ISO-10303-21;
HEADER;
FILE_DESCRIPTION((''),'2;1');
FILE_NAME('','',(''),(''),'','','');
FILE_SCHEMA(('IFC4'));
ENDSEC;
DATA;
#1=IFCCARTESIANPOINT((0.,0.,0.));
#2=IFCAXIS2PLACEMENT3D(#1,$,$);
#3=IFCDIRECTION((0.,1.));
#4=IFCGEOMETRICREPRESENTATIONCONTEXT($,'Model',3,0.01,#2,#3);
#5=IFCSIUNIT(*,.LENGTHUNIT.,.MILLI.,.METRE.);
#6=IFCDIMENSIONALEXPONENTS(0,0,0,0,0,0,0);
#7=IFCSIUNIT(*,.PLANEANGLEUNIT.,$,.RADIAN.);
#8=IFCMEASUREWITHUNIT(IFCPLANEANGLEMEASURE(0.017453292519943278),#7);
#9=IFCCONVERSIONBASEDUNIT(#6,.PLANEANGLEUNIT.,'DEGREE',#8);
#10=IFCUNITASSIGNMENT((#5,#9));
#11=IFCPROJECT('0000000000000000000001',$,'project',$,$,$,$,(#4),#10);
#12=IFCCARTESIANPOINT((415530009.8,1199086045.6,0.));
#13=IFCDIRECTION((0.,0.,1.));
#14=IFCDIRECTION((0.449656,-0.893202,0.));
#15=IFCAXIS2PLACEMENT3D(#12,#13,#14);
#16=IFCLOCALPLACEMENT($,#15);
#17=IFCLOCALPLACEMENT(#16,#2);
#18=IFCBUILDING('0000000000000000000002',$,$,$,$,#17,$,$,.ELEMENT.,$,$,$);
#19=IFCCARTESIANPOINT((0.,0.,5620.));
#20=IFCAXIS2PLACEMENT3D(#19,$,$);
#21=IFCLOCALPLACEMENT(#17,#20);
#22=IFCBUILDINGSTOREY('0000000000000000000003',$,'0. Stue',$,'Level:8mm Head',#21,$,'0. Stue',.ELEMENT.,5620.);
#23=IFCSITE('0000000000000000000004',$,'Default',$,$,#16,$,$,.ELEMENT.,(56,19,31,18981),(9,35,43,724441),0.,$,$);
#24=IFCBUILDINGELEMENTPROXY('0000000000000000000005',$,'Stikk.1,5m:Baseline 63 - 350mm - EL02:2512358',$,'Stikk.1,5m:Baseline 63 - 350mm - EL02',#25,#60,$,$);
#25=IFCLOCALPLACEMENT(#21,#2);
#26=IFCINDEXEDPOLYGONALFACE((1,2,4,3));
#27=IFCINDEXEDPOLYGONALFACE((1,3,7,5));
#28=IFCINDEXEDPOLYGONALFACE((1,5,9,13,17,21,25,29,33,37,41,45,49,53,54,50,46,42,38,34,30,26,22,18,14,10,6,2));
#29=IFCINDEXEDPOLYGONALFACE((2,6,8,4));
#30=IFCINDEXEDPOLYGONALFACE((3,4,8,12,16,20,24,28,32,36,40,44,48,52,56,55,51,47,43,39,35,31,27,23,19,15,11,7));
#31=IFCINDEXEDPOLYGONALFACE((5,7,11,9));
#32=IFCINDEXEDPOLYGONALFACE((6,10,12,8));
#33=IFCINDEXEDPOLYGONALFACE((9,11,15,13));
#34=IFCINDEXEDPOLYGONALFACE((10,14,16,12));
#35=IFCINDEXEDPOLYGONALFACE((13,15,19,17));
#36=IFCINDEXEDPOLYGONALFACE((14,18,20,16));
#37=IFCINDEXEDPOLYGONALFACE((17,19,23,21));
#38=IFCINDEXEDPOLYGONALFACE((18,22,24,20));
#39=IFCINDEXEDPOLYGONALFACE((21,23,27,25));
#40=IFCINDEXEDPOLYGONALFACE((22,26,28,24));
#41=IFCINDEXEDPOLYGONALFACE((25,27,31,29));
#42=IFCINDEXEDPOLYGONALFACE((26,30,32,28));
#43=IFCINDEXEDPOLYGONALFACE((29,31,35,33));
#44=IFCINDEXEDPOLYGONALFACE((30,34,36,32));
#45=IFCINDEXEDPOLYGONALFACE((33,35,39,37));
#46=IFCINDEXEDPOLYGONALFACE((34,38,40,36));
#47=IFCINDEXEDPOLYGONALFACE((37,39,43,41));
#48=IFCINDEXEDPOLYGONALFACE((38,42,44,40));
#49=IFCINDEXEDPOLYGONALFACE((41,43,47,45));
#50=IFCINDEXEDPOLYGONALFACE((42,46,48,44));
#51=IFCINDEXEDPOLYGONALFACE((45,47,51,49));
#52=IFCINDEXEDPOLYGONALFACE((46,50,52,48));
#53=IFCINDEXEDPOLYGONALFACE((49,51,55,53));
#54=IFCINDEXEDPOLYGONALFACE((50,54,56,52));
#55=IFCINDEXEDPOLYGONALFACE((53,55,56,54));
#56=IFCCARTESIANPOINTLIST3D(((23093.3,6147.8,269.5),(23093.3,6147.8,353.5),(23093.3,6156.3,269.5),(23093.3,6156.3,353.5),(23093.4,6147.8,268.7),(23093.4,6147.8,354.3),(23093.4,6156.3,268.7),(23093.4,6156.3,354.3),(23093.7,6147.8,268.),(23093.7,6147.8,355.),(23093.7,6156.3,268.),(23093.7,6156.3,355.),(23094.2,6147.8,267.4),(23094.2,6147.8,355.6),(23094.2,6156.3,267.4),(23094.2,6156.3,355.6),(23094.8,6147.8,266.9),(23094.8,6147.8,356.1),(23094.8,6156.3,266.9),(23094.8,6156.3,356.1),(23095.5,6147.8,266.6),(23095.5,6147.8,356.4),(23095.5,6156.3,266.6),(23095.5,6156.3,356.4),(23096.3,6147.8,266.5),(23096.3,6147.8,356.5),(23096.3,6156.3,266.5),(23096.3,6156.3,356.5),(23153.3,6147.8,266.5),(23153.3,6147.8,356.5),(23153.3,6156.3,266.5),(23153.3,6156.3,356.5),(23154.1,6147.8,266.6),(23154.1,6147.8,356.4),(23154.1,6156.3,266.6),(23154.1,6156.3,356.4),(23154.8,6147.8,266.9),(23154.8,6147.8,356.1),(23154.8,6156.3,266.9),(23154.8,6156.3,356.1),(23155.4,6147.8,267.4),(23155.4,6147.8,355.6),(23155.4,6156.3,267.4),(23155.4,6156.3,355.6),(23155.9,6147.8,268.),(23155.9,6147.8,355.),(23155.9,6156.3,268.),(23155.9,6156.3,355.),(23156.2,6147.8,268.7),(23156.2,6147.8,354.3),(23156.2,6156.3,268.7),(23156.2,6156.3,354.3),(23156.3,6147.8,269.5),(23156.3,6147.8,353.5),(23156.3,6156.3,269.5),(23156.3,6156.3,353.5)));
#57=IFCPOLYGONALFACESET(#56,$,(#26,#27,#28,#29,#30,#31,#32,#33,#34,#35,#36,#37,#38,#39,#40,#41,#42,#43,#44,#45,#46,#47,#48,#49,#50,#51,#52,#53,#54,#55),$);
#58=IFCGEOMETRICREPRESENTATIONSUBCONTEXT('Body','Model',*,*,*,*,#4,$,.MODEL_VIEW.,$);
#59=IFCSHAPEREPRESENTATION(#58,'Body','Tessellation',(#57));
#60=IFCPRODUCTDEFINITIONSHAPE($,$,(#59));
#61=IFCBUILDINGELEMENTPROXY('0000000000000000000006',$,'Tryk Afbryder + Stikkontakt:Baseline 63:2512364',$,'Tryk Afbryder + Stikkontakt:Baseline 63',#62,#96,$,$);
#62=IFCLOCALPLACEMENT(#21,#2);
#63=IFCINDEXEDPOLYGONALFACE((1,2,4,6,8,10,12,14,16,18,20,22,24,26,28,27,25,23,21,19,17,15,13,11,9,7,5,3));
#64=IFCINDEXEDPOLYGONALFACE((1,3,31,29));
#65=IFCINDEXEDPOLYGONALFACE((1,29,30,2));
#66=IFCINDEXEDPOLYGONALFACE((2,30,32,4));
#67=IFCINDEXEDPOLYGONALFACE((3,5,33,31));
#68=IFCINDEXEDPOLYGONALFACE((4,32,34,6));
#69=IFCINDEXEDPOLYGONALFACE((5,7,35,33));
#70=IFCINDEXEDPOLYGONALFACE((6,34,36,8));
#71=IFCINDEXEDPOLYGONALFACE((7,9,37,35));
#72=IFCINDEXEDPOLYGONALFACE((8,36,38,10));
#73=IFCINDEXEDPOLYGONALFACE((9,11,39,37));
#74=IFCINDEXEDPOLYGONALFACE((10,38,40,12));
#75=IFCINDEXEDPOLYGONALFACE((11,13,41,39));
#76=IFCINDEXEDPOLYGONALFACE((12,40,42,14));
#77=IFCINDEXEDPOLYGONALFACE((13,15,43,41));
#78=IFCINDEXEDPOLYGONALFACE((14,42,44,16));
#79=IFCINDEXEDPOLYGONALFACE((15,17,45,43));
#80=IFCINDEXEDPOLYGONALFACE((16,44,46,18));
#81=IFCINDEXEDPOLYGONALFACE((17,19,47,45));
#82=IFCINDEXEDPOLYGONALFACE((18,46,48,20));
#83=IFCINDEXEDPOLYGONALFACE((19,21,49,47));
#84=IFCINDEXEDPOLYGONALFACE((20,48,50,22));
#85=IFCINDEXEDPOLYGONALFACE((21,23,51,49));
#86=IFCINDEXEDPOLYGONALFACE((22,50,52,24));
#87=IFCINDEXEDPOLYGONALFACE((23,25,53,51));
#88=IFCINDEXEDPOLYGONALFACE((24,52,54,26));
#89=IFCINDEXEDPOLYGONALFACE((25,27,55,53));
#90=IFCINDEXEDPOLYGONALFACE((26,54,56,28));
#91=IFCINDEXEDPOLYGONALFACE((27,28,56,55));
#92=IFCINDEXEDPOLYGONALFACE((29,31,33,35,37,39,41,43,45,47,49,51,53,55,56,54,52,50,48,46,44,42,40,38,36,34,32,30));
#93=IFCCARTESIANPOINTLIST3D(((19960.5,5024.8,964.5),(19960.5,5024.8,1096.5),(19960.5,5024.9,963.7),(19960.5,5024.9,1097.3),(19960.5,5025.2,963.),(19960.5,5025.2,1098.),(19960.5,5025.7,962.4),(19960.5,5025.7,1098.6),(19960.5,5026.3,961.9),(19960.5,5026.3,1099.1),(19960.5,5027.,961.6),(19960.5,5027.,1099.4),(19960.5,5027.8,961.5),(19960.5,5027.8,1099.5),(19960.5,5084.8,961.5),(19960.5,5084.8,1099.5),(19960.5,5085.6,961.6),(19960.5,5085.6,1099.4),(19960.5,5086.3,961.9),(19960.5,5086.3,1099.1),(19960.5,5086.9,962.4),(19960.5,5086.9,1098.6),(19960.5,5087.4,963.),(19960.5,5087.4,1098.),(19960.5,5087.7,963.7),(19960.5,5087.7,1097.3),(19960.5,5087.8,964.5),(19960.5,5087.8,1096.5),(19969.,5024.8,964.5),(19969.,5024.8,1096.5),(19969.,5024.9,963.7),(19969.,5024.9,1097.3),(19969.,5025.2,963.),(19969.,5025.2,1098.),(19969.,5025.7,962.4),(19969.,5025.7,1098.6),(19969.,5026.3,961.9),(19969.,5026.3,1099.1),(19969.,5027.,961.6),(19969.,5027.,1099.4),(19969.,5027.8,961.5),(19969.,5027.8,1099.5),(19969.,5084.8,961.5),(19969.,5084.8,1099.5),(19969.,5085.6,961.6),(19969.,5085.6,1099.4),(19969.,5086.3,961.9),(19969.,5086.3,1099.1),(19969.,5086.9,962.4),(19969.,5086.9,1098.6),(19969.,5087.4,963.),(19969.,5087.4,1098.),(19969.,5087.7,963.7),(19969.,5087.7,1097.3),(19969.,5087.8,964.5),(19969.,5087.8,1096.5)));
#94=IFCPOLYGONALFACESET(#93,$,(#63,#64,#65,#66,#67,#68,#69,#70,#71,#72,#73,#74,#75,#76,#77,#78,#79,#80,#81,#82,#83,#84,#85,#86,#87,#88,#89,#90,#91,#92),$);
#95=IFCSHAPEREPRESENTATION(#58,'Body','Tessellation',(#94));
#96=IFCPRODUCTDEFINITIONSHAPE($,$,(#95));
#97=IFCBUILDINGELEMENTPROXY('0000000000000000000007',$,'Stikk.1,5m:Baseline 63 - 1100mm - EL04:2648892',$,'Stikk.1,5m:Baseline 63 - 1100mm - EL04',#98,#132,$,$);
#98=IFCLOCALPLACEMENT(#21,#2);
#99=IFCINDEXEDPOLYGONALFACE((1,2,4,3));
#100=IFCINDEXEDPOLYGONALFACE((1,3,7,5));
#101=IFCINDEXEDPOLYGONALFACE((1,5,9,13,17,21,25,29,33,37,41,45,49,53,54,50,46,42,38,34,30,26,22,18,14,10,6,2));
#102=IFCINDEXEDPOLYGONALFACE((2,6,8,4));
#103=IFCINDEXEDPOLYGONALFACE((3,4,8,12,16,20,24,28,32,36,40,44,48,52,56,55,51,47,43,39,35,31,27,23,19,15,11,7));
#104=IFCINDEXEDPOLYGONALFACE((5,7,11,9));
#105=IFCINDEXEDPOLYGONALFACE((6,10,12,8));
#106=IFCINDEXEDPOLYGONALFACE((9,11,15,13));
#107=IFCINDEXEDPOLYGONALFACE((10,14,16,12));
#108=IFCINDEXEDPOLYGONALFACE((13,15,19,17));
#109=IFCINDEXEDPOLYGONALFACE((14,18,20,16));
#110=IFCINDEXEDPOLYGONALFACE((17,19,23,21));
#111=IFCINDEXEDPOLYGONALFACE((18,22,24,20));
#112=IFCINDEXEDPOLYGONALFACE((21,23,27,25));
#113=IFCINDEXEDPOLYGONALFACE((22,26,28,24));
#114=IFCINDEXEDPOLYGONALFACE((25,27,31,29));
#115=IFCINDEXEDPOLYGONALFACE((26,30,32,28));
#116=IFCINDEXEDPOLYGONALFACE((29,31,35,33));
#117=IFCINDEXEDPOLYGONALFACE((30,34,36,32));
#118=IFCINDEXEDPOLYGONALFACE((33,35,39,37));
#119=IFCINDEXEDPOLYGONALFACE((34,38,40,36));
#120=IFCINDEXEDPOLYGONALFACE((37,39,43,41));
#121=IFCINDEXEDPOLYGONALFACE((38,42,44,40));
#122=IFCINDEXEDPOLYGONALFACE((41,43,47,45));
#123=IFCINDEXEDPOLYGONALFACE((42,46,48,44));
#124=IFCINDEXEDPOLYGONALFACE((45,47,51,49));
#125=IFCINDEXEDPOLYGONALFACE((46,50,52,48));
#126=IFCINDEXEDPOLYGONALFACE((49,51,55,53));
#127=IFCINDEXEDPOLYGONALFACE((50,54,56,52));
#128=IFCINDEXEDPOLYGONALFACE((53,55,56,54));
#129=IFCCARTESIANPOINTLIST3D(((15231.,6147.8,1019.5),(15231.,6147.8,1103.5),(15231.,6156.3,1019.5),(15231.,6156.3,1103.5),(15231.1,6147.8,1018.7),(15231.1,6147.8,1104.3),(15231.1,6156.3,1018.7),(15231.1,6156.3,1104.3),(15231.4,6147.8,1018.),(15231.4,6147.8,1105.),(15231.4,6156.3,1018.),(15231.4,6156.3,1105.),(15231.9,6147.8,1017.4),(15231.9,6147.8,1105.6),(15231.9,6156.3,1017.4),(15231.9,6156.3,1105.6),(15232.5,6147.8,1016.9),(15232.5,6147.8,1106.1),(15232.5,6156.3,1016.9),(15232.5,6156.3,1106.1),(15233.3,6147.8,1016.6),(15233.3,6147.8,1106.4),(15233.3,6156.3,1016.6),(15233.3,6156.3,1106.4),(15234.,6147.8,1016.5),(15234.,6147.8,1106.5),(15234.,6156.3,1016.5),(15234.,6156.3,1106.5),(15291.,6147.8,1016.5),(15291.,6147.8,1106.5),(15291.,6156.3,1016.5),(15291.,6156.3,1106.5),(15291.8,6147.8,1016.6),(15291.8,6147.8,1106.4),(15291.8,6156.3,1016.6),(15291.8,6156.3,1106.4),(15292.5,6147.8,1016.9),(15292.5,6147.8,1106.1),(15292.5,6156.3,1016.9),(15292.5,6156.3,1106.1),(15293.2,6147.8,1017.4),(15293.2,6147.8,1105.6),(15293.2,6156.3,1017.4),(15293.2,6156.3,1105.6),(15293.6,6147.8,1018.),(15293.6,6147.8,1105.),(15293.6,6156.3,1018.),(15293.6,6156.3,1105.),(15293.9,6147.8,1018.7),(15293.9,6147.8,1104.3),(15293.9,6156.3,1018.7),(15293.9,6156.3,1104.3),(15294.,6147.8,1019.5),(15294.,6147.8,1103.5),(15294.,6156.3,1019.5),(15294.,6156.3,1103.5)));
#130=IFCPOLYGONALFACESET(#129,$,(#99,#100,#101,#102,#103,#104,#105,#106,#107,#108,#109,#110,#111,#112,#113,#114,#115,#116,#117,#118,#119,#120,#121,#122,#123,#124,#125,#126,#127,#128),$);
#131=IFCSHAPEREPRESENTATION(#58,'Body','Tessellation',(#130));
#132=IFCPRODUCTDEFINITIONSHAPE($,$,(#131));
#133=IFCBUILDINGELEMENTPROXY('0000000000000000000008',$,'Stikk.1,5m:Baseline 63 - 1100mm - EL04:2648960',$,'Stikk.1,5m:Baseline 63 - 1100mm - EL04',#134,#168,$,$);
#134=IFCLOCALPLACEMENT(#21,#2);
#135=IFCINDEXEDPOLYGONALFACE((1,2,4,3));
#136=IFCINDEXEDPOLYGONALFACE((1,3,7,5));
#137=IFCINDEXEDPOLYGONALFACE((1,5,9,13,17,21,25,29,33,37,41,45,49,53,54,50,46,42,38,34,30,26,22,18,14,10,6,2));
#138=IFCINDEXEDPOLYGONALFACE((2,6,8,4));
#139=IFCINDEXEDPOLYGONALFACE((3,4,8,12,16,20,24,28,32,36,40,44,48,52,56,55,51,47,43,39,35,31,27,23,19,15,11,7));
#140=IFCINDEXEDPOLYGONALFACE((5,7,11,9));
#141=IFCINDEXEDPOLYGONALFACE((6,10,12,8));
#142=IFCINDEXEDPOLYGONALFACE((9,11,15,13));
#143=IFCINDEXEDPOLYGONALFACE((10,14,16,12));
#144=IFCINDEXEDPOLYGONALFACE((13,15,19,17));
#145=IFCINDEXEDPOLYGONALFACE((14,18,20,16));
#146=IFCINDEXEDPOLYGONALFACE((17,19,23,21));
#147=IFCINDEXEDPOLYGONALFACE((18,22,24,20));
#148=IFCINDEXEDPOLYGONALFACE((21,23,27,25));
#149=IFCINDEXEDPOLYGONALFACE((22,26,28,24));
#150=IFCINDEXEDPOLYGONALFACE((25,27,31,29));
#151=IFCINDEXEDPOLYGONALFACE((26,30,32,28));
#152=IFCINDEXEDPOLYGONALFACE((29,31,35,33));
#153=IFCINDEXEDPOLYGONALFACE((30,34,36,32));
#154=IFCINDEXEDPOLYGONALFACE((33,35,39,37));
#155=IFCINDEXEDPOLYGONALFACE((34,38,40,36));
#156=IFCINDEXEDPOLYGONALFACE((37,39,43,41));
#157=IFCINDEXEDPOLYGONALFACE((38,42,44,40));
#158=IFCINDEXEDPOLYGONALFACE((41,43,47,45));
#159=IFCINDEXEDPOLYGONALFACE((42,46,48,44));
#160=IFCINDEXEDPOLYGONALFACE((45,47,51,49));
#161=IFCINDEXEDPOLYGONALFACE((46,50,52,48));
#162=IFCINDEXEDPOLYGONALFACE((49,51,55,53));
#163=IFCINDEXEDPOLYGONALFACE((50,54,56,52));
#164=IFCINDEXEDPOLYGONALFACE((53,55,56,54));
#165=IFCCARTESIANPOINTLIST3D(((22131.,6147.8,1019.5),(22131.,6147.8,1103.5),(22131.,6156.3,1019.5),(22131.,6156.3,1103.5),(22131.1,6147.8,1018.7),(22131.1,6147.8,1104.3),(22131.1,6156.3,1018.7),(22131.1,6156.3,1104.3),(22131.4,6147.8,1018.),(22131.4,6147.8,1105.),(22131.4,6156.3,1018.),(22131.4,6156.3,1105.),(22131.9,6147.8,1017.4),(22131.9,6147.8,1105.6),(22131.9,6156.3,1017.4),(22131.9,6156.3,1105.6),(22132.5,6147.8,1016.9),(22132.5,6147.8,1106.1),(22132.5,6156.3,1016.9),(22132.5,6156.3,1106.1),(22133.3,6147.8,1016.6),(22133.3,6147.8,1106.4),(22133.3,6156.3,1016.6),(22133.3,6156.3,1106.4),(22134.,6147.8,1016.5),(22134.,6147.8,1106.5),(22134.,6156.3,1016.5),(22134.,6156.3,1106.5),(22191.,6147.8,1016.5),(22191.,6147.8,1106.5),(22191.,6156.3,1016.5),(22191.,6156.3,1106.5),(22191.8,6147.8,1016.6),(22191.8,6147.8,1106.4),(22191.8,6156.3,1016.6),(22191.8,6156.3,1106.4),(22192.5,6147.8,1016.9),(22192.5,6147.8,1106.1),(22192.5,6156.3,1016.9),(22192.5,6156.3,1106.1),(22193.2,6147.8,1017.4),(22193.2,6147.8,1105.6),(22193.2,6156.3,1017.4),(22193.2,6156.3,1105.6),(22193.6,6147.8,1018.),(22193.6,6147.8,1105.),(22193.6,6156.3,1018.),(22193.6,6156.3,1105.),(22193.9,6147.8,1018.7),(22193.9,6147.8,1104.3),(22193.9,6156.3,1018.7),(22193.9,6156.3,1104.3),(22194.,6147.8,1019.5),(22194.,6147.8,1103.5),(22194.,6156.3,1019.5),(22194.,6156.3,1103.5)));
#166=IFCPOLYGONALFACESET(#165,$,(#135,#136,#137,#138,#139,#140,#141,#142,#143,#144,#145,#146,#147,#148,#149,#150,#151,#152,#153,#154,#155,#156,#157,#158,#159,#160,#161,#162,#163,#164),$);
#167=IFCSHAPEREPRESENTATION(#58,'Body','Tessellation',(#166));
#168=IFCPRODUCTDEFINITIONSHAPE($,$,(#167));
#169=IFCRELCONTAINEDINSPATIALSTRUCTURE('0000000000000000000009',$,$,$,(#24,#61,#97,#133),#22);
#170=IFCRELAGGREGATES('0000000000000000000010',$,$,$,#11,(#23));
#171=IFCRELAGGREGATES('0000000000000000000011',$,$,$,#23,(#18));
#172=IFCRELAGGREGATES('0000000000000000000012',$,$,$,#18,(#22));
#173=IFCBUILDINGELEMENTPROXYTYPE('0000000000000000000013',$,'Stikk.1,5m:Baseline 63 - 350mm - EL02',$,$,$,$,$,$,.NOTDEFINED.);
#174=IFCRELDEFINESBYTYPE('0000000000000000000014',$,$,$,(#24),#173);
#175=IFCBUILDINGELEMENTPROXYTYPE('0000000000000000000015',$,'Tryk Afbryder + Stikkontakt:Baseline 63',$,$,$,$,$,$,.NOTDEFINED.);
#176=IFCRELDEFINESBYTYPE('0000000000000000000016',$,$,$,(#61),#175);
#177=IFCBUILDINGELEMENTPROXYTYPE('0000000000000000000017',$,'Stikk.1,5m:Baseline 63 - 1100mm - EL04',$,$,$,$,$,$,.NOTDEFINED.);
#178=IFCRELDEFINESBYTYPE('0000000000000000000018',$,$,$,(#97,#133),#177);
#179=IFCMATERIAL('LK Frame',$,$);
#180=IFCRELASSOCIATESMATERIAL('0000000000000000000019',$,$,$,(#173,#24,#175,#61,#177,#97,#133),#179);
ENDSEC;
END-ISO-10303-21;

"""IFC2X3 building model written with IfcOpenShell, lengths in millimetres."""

from ifc_helpers import new_model, entity, si_unit, converted_unit, direction, frame, frame_2d, origin, place, context, subcontext, project, spatial, polyline, circle_curve, parameter, trimmed, segment, composite_curve, outline, extrude, source, transform, mapped, material, type_object, type_shapes, element, save


model = new_model("IFC2X3")

# Units and contexts
model_context = context("Model", 3, precision=0.01, world=origin(), true_north=direction((0.0, 1.0)))
body_context = subcontext(model_context, "Body", "Model", "MODEL_VIEW")
ifc_project = project(units=[si_unit("LENGTHUNIT", "METRE", prefix="MILLI"), converted_unit("PLANEANGLEUNIT", "DEGREE", entity("IfcPlaneAngleMeasure", 0.017453292519943278), si_unit("PLANEANGLEUNIT", "RADIAN"), dimensions=[0, 0, 0, 0, 0, 0, 0])], contexts=[model_context])

# Site, building, storey
site_placement = place(None, frame((415530009.8, 1199086045.6, 0.0), z_axis=(0.0, 0.0, 1.0), x_axis=(0.449656, -0.893202, 0.0)))
site = spatial("IfcSite", under=ifc_project, at=site_placement, Name="Default", CompositionType="ELEMENT", RefLatitude=(56, 19, 31, 18981), RefLongitude=(9, 35, 43, 724441), RefElevation=0.0)
building_placement = place(site_placement, origin())
building = spatial("IfcBuilding", under=site, at=building_placement, CompositionType="ELEMENT")
storey_placement = place(building_placement, frame((0.0, 0.0, 5620.0)))
storey = spatial("IfcBuildingStorey", under=building, at=storey_placement, Name="0. Stue", ObjectType="Level:8mm Head", LongName="0. Stue", CompositionType="ELEMENT", Elevation=5620.0)

# Building element proxies
ifc_material_1 = material(Name="LK Frame")
building_element_proxy_type_1 = type_object("IfcBuildingElementProxyType", Name="Stikk.1,5m:Baseline 63 - 350mm - EL02", PredefinedType="NOTDEFINED", material=ifc_material_1)
shared_shape_1 = source(origin(), body_context, "Body", "SweptSolid", [
    extrude(outline(composite_curve([segment(polyline([(-42.0, -31.5), (42.0, -31.5)]), True, "CONTINUOUS"), segment(trimmed(circle_curve(frame_2d((42.0, -28.5), x_axis=(-1.0, 0.0)), 3.0), [parameter(90.0)], [parameter(180.0)], True, "PARAMETER"), True, "CONTINUOUS"), segment(polyline([(45.0, -28.5), (45.0, 28.5)]), True, "CONTINUOUS"), segment(trimmed(circle_curve(frame_2d((42.0, 28.5), x_axis=(-1.0, 0.0)), 3.0), [parameter(180.0)], [parameter(270.0)], True, "PARAMETER"), True, "CONTINUOUS"), segment(polyline([(42.0, 31.5), (-42.0, 31.5)]), True, "CONTINUOUS"), segment(trimmed(circle_curve(frame_2d((-42.0, 28.5), x_axis=(1.0, 0.0)), 3.0), [parameter(90.0)], [parameter(180.0)], True, "PARAMETER"), True, "CONTINUOUS"), segment(polyline([(-45.0, 28.5), (-45.0, -28.5)]), True, "CONTINUOUS"), segment(trimmed(circle_curve(frame_2d((-42.0, -28.5), x_axis=(1.0, 0.0)), 3.0), [parameter(180.0)], [parameter(270.0)], True, "PARAMETER"), True, "CONTINUOUS")], self_intersect=False)), frame((0.0, -38.5, 0.0), z_axis=(0.0, 0.0, 1.0), x_axis=(0.0, 1.0, 0.0)), (0.0, 0.0, 1.0), 8.5),
])
type_shapes(building_element_proxy_type_1, [shared_shape_1])
for number, where, z_axis, x_axis, name in (
    (1, (23124.8, 6156.3, 350.0), (0.0, -1.0, 0.0), (1.0, 0.0, 0.0), "Stikk.1,5m:Baseline 63 - 350mm - EL02:2512358"),
):
    element("IfcBuildingElementProxy", number, at=place(storey_placement, frame(where, z_axis=z_axis, x_axis=x_axis)), inside=storey, type_object=building_element_proxy_type_1, material=ifc_material_1, Name=name, ObjectType="Stikk.1,5m:Baseline 63 - 350mm - EL02", context=body_context, shape_type="MappedRepresentation", body=[
        mapped(shared_shape_1, transform((0.0, 0.0, 0.0), scale=1.0)),
    ])
building_element_proxy_type_2 = type_object("IfcBuildingElementProxyType", Name="Tryk Afbryder + Stikkontakt:Baseline 63", PredefinedType="NOTDEFINED", material=ifc_material_1)
shared_shape_2 = source(origin(), body_context, "Body", "SweptSolid", [
    extrude(outline(composite_curve([segment(polyline([(-66.0, -31.5), (66.0, -31.5)]), True, "CONTINUOUS"), segment(trimmed(circle_curve(frame_2d((66.0, -28.5), x_axis=(-1.0, 0.0)), 3.0), [parameter(90.0)], [parameter(180.0)], True, "PARAMETER"), True, "CONTINUOUS"), segment(polyline([(69.0, -28.5), (69.0, 28.5)]), True, "CONTINUOUS"), segment(trimmed(circle_curve(frame_2d((66.0, 28.5), x_axis=(-1.0, 0.0)), 3.0), [parameter(180.0)], [parameter(270.0)], True, "PARAMETER"), True, "CONTINUOUS"), segment(polyline([(66.0, 31.5), (-66.0, 31.5)]), True, "CONTINUOUS"), segment(trimmed(circle_curve(frame_2d((-66.0, 28.5), x_axis=(1.0, 0.0)), 3.0), [parameter(90.0)], [parameter(180.0)], True, "PARAMETER"), True, "CONTINUOUS"), segment(polyline([(-69.0, 28.5), (-69.0, -28.5)]), True, "CONTINUOUS"), segment(trimmed(circle_curve(frame_2d((-66.0, -28.5), x_axis=(1.0, 0.0)), 3.0), [parameter(180.0)], [parameter(270.0)], True, "PARAMETER"), True, "CONTINUOUS")], self_intersect=False)), frame((0.0, -69.5, 0.0), z_axis=(0.0, 0.0, 1.0), x_axis=(0.0, 1.0, 0.0)), (0.0, 0.0, 1.0), 8.5),
])
type_shapes(building_element_proxy_type_2, [shared_shape_2])
proxy_1_placement = place(storey_placement, frame((19960.5, 5056.3, 1100.0), z_axis=(1.0, 0.0, 0.0), x_axis=(0.0, 1.0, 0.0)))
element("IfcBuildingElementProxy", 2, at=proxy_1_placement, inside=storey, type_object=building_element_proxy_type_2, material=ifc_material_1, Name="Tryk Afbryder + Stikkontakt:Baseline 63:2512364", ObjectType="Tryk Afbryder + Stikkontakt:Baseline 63", context=body_context, shape_type="MappedRepresentation", body=[
    mapped(shared_shape_2, transform((0.0, 0.0, 0.0), scale=1.0)),
])
building_element_proxy_type_3 = type_object("IfcBuildingElementProxyType", Name="Stikk.1,5m:Baseline 63 - 1100mm - EL04", PredefinedType="NOTDEFINED", material=ifc_material_1)
shared_shape_3 = source(origin(), body_context, "Body", "SweptSolid", [
    extrude(outline(composite_curve([segment(trimmed(circle_curve(frame_2d((-42.0, 28.5), x_axis=(1.0, 0.0)), 3.0), [parameter(90.0)], [parameter(180.0)], True, "PARAMETER"), True, "CONTINUOUS"), segment(polyline([(-45.0, 28.5), (-45.0, -28.5)]), True, "CONTINUOUS"), segment(trimmed(circle_curve(frame_2d((-42.0, -28.5), x_axis=(1.0, 0.0)), 3.0), [parameter(180.0)], [parameter(270.0)], True, "PARAMETER"), True, "CONTINUOUS"), segment(polyline([(-42.0, -31.5), (42.0, -31.5)]), True, "CONTINUOUS"), segment(trimmed(circle_curve(frame_2d((42.0, -28.5), x_axis=(-1.0, 0.0)), 3.0), [parameter(90.0)], [parameter(180.0)], True, "PARAMETER"), True, "CONTINUOUS"), segment(polyline([(45.0, -28.5), (45.0, 28.5)]), True, "CONTINUOUS"), segment(trimmed(circle_curve(frame_2d((42.0, 28.5), x_axis=(-1.0, 0.0)), 3.0), [parameter(180.0)], [parameter(270.0)], True, "PARAMETER"), True, "CONTINUOUS"), segment(polyline([(42.0, 31.5), (-42.0, 31.5)]), True, "CONTINUOUS")], self_intersect=False)), frame((0.0, 38.5, 0.0), z_axis=(0.0, 0.0, 1.0), x_axis=(0.0, -1.0, 0.0)), (0.0, 0.0, 1.0), 8.5),
])
type_shapes(building_element_proxy_type_3, [shared_shape_3])
for number, where, z_axis, x_axis, name in (
    (3, (15262.5, 6156.3, 1100.0), (0.0, -1.0, 0.0), (-1.0, 0.0, 0.0), "Stikk.1,5m:Baseline 63 - 1100mm - EL04:2648892"),
    (4, (22162.5, 6156.3, 1100.0), (0.0, -1.0, 0.0), (-1.0, 0.0, 0.0), "Stikk.1,5m:Baseline 63 - 1100mm - EL04:2648960"),
):
    element("IfcBuildingElementProxy", number, at=place(storey_placement, frame(where, z_axis=z_axis, x_axis=x_axis)), inside=storey, type_object=building_element_proxy_type_3, material=ifc_material_1, Name=name, ObjectType="Stikk.1,5m:Baseline 63 - 1100mm - EL04", context=body_context, shape_type="MappedRepresentation", body=[
        mapped(shared_shape_3, transform((0.0, 0.0, 0.0), scale=1.0)),
    ])

save(model, "model.ifc")
